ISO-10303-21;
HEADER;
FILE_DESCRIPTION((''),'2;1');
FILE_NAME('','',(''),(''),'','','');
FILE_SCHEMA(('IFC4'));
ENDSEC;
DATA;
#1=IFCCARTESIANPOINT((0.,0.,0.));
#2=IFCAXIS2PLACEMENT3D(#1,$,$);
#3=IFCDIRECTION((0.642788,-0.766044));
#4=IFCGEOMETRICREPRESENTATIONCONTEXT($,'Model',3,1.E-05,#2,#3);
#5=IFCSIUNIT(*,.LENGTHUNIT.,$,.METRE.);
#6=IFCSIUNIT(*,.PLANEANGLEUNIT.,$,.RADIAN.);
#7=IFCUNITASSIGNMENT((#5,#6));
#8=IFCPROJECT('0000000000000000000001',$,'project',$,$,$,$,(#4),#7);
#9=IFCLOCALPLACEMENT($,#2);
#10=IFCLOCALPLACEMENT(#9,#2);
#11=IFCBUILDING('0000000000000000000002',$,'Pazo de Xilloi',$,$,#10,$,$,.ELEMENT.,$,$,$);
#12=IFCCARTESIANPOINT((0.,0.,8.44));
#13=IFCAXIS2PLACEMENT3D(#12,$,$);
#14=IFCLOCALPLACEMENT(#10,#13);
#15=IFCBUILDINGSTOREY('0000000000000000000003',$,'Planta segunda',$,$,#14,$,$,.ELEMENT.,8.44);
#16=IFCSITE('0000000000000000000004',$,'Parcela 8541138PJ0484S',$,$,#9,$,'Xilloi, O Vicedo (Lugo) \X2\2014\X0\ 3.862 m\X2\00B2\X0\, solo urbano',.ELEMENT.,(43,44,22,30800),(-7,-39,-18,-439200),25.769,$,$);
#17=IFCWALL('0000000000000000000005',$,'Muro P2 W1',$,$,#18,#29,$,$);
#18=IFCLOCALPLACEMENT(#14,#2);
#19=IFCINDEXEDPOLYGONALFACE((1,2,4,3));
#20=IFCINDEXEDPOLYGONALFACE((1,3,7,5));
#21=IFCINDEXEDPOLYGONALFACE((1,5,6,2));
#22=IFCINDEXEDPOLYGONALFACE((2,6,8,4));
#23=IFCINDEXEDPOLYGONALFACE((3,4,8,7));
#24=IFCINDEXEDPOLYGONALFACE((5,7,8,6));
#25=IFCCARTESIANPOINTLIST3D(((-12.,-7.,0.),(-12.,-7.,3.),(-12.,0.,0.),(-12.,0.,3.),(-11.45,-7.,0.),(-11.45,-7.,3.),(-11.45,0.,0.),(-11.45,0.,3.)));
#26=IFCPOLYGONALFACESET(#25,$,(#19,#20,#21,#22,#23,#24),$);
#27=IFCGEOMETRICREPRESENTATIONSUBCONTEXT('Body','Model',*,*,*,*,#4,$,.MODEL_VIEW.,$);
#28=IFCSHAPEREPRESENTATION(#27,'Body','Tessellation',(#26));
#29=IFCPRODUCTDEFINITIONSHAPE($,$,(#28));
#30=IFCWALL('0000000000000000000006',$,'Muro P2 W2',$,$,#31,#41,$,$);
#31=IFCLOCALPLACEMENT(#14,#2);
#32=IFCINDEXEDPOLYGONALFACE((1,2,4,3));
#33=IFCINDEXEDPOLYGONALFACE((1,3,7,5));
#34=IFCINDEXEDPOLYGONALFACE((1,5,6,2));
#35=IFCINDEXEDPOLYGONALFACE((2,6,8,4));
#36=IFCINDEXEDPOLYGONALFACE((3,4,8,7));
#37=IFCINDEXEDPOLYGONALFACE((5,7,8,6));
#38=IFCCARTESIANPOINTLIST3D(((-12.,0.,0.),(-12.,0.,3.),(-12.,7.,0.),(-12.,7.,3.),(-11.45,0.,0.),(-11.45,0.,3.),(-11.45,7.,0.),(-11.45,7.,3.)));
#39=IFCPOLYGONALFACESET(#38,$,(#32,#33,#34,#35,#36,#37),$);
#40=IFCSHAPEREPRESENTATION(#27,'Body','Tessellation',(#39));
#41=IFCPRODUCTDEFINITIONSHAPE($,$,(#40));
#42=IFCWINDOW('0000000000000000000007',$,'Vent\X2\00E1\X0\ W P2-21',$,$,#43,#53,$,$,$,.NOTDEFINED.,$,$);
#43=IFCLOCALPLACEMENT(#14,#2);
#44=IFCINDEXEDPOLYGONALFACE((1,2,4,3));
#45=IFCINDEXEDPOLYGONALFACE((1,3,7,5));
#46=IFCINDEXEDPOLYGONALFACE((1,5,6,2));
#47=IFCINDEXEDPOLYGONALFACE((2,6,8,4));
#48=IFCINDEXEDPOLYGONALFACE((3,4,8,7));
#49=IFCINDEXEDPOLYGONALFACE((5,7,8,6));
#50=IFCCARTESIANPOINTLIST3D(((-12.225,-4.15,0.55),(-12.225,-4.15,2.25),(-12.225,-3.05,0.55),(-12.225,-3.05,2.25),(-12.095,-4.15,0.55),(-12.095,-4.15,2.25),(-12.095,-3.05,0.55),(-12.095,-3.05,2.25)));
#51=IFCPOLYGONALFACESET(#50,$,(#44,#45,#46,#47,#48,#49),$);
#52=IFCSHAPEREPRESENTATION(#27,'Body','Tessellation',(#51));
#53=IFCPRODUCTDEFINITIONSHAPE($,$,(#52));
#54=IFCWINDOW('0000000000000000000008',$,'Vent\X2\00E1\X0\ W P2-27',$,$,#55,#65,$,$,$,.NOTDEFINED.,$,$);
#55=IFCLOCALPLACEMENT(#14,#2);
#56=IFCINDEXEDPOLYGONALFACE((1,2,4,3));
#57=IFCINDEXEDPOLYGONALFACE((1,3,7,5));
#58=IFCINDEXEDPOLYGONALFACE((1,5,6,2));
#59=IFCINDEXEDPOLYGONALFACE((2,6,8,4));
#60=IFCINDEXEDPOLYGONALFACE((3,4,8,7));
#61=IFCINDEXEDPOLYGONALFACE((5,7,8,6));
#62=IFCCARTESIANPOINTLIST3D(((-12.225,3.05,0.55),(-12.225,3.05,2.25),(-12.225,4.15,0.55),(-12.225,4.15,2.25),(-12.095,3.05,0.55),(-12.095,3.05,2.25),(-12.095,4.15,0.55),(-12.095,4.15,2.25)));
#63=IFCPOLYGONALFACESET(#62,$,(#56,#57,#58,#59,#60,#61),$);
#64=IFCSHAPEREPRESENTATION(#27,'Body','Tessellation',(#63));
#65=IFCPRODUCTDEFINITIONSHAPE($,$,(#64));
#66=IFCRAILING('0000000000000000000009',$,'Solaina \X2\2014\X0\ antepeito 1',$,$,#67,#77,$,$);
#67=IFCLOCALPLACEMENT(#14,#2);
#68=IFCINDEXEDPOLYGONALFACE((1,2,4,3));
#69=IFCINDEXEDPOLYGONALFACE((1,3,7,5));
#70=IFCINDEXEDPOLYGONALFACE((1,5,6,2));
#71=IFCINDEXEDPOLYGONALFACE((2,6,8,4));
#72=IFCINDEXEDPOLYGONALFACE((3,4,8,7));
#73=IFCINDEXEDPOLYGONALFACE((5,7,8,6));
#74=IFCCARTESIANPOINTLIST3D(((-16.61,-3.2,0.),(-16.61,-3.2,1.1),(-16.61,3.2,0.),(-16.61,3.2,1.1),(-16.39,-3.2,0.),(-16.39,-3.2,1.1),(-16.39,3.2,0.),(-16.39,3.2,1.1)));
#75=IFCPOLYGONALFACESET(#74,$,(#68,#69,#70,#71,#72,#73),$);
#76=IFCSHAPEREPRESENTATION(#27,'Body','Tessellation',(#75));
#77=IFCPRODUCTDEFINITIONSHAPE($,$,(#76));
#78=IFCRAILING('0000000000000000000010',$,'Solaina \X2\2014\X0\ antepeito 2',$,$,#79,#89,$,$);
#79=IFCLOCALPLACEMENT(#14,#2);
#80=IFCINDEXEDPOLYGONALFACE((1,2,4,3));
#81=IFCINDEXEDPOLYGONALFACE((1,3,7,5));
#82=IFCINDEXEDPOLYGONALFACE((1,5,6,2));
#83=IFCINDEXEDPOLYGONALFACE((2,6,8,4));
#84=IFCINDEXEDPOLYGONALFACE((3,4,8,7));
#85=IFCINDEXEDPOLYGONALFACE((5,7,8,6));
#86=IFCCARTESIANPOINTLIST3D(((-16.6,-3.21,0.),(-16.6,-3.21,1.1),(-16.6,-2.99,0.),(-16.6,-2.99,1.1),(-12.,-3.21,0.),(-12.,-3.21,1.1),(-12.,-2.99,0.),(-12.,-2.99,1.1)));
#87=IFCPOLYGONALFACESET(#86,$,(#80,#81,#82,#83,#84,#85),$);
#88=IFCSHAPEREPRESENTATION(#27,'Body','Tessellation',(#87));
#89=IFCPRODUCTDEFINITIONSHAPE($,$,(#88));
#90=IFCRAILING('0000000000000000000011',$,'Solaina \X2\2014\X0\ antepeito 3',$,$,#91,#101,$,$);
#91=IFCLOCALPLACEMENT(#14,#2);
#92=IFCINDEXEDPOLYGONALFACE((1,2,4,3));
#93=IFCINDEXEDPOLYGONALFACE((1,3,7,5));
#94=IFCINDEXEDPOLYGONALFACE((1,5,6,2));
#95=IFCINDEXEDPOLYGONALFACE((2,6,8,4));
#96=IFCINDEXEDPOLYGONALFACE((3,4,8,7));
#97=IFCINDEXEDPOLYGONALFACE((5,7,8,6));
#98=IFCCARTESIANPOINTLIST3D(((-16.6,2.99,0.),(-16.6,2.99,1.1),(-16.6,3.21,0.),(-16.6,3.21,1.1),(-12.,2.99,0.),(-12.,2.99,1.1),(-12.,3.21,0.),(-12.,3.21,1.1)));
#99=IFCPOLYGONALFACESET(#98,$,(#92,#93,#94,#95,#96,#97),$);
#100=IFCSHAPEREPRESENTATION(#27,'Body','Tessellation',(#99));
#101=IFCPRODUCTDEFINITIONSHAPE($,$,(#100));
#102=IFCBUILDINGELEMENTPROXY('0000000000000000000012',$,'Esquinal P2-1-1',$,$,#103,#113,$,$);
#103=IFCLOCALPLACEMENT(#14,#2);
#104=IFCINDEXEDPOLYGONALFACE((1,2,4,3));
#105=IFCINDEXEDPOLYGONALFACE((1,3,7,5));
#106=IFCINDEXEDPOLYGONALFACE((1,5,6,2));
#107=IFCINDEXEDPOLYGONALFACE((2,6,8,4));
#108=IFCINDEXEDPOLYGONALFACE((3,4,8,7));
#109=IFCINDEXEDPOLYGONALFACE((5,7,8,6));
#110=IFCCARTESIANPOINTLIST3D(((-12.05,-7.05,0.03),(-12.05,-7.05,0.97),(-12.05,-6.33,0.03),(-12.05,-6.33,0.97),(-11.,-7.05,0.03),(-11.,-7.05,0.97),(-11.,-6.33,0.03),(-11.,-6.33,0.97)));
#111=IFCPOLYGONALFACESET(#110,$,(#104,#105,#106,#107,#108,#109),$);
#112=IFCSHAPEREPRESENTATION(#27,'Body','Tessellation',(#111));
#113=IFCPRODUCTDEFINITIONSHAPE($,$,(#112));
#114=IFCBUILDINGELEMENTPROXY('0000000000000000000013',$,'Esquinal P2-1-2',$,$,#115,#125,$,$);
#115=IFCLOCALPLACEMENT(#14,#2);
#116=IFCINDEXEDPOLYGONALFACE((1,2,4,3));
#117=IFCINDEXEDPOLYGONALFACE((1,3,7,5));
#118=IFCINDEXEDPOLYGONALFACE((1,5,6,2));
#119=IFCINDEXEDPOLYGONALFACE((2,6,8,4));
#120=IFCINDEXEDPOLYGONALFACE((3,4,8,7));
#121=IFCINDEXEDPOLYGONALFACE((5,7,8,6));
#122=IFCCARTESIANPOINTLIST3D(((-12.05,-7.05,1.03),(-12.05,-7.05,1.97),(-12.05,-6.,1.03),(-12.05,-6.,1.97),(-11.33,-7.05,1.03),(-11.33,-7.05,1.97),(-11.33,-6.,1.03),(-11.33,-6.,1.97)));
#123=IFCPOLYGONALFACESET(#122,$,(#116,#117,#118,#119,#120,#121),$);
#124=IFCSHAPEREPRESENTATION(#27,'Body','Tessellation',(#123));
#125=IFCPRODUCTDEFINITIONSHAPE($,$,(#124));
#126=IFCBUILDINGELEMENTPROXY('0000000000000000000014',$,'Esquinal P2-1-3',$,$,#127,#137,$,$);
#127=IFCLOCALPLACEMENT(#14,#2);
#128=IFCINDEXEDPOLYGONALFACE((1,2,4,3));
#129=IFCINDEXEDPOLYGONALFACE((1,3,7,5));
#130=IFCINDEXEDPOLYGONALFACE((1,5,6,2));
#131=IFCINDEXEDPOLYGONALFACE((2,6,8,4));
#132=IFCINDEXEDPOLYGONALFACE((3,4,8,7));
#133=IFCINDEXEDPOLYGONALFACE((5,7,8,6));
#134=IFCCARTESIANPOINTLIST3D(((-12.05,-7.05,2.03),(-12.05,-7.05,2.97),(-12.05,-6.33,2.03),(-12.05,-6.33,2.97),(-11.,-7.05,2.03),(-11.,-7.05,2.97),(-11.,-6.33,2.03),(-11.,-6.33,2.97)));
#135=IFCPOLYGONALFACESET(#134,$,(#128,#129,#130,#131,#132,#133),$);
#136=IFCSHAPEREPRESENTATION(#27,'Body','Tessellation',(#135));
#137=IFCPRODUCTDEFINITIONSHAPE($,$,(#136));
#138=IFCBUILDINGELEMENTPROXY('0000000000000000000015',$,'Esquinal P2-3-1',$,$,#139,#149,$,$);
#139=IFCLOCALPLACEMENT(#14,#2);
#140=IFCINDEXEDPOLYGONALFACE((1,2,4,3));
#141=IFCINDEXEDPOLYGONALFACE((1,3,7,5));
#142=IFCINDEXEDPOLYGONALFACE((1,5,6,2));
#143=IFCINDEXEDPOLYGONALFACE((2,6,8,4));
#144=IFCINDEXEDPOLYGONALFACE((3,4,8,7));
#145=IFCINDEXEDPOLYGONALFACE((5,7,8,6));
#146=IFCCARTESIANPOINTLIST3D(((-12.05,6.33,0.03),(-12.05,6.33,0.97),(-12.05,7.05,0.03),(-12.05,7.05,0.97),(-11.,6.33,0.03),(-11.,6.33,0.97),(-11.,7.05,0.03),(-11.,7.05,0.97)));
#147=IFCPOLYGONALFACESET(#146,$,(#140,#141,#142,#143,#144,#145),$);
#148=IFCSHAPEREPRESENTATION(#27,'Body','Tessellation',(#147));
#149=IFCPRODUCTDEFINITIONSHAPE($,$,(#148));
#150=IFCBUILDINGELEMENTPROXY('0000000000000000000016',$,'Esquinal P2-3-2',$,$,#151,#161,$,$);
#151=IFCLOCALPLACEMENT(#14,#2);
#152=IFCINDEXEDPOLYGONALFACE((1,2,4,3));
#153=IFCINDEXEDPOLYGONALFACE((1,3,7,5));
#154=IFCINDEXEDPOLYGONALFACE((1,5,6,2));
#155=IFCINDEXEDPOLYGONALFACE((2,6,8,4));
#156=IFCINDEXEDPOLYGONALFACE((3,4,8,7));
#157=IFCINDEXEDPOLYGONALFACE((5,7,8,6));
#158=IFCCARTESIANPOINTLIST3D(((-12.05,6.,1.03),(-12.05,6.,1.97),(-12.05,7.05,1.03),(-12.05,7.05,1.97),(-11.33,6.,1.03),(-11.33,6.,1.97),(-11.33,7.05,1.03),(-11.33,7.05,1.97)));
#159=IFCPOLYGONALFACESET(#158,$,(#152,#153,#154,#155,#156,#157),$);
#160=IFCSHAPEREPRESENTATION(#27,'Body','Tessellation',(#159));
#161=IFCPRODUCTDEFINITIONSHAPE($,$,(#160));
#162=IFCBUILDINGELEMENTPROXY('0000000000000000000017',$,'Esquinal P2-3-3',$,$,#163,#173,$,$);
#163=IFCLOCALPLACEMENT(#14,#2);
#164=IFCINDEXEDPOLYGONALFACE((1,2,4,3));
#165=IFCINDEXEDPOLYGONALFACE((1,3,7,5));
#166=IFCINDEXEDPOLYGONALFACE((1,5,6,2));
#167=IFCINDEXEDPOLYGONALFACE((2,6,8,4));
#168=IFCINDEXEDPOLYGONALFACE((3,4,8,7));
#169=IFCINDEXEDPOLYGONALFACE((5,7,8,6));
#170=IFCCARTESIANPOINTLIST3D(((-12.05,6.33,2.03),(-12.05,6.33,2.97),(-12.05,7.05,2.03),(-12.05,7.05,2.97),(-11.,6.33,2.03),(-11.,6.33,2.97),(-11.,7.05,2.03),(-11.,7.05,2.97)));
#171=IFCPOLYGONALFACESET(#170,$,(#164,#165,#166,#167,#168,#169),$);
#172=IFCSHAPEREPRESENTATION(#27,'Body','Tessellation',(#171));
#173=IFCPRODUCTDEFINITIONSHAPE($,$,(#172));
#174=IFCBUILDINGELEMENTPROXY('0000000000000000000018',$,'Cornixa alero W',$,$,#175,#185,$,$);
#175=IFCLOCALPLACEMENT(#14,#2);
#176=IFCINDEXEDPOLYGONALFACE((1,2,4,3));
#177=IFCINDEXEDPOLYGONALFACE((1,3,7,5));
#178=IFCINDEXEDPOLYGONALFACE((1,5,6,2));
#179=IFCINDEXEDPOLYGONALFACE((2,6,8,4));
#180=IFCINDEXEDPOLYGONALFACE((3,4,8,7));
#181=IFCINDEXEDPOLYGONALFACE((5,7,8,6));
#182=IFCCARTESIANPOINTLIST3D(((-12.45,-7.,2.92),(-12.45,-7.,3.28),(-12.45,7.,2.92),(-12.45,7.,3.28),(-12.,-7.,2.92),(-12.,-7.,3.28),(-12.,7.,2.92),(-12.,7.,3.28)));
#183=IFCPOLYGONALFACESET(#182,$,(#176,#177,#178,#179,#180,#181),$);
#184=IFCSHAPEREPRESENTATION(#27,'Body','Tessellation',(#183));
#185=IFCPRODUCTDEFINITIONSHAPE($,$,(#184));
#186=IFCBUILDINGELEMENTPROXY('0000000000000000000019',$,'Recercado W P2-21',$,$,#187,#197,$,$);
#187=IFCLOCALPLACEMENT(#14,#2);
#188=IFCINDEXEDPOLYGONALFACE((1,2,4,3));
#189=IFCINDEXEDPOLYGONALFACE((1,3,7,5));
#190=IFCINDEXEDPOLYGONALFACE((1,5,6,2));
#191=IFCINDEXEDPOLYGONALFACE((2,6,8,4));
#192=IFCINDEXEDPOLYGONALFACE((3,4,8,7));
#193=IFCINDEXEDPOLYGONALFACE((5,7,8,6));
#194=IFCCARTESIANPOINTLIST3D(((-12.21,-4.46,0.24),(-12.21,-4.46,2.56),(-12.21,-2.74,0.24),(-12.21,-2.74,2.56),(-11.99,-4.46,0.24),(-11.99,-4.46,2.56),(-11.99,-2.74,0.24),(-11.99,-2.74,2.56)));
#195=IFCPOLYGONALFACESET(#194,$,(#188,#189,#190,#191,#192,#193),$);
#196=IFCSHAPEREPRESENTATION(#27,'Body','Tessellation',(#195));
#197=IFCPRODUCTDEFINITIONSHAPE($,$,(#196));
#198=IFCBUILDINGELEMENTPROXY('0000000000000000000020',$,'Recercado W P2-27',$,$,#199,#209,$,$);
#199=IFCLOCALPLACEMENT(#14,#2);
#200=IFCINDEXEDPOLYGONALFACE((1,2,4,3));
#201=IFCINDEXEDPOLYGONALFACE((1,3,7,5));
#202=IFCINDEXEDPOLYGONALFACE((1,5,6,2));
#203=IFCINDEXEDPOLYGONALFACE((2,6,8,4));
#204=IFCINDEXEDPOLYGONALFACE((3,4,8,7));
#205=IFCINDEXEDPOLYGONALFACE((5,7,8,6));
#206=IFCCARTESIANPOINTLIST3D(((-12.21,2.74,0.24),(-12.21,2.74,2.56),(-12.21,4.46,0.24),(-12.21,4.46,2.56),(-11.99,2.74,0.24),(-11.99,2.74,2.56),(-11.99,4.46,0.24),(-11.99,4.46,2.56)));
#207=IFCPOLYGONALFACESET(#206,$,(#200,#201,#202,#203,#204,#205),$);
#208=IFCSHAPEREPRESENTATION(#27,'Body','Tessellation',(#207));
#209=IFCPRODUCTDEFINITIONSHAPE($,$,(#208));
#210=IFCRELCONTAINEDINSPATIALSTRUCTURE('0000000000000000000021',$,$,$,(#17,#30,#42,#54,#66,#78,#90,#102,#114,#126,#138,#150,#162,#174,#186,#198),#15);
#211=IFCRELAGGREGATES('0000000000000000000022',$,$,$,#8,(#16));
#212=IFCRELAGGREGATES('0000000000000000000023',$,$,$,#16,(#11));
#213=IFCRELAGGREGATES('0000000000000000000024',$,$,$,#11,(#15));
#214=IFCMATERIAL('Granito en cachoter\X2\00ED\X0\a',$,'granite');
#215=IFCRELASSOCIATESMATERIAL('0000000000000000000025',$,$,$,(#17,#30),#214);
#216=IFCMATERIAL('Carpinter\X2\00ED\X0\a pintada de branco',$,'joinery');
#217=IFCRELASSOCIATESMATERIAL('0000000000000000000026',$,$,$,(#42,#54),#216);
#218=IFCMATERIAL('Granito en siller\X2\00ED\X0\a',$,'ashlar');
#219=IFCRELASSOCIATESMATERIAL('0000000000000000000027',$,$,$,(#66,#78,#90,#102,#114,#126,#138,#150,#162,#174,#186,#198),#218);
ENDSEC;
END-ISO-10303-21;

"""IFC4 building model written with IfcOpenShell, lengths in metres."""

from ifc_helpers import new_model, si_unit, direction, frame, origin, origin_2d, place, context, subcontext, project, spatial, rectangle, extrude, material, element, save


model = new_model("IFC4")

# Units and contexts
model_context = context("Model", 3, precision=1e-05, world=origin(), true_north=direction((0.642788, -0.766044)))
body_context = subcontext(model_context, "Body", "Model", "MODEL_VIEW")
ifc_project = project(units=[si_unit("LENGTHUNIT", "METRE"), si_unit("PLANEANGLEUNIT", "RADIAN")], contexts=[model_context])

# Site, building, storey
site_placement = place(None, origin())
site = spatial("IfcSite", under=ifc_project, at=site_placement, Name="Parcela 8541138PJ0484S", LongName="Xilloi, O Vicedo (Lugo) — 3.862 m², solo urbano", CompositionType="ELEMENT", RefLatitude=(43, 44, 22, 30800), RefLongitude=(-7, -39, -18, -439200), RefElevation=25.769)
building_placement = place(site_placement, origin())
building = spatial("IfcBuilding", under=site, at=building_placement, Name="Pazo de Xilloi", CompositionType="ELEMENT")
storey_placement = place(building_placement, frame((0.0, 0.0, 8.44)))
storey = spatial("IfcBuildingStorey", under=building, at=storey_placement, Name="Planta segunda", CompositionType="ELEMENT", Elevation=8.44)

# Shared definitions
ifc_material_1 = material(Name="Granito en sillería", Category="ashlar")

# Walls
ifc_material_2 = material(Name="Granito en cachotería", Category="granite")
for number, where, name in (
    (1, (-11.725, -3.5, 1.5), "Muro P2 W1"),
    (2, (-11.725, 3.5, 1.5), "Muro P2 W2"),
):
    element("IfcWall", number, at=place(storey_placement, frame(where)), inside=storey, material=ifc_material_2, Name=name, context=body_context, shape_type="SweptSolid", body=[
        extrude(rectangle(XDim=0.55, YDim=7.0, at=origin_2d()), frame((0.0, 0.0, -1.5)), (0.0, 0.0, 1.0), 3.0),
    ])

# Windows
ifc_material_3 = material(Name="Carpintería pintada de branco", Category="joinery")
for number, where, name in (
    (3, (-12.16, -3.6, 1.4), "Ventá W P2-21"),
    (4, (-12.16, 3.6, 1.4), "Ventá W P2-27"),
):
    element("IfcWindow", number, at=place(storey_placement, frame(where)), inside=storey, material=ifc_material_3, Name=name, PredefinedType="NOTDEFINED", context=body_context, shape_type="SweptSolid", body=[
        extrude(rectangle(XDim=0.13, YDim=1.1, at=origin_2d()), frame((0.0, 0.0, -0.85)), (0.0, 0.0, 1.0), 1.7),
    ])

# Railings
railing_placement = place(storey_placement, frame((-16.5, 0.0, 0.55)))
element("IfcRailing", 5, at=railing_placement, inside=storey, material=ifc_material_1, Name="Solaina — antepeito 1", context=body_context, shape_type="SweptSolid", body=[
    extrude(rectangle(XDim=0.22, YDim=6.4, at=origin_2d()), frame((0.0, 0.0, -0.55)), (0.0, 0.0, 1.0), 1.1),
])
for number, where, name in (
    (6, (-14.3, -3.1, 0.55), "Solaina — antepeito 2"),
    (7, (-14.3, 3.1, 0.55), "Solaina — antepeito 3"),
):
    element("IfcRailing", number, at=place(storey_placement, frame(where)), inside=storey, material=ifc_material_1, Name=name, context=body_context, shape_type="SweptSolid", body=[
        extrude(rectangle(XDim=4.6, YDim=0.22, at=origin_2d()), frame((0.0, 0.0, -0.55)), (0.0, 0.0, 1.0), 1.1),
    ])

# Building element proxies
proxy_1_placement = place(storey_placement, frame((-11.525, -6.69, 0.5)))
element("IfcBuildingElementProxy", 8, at=proxy_1_placement, inside=storey, material=ifc_material_1, Name="Esquinal P2-1-1", context=body_context, shape_type="SweptSolid", body=[
    extrude(rectangle(XDim=1.05, YDim=0.72, at=origin_2d()), frame((0.0, 0.0, -0.47)), (0.0, 0.0, 1.0), 0.94),
])
proxy_2_placement = place(storey_placement, frame((-11.69, -6.525, 1.5)))
element("IfcBuildingElementProxy", 9, at=proxy_2_placement, inside=storey, material=ifc_material_1, Name="Esquinal P2-1-2", context=body_context, shape_type="SweptSolid", body=[
    extrude(rectangle(XDim=0.72, YDim=1.05, at=origin_2d()), frame((0.0, 0.0, -0.47)), (0.0, 0.0, 1.0), 0.94),
])
for number, where, name in (
    (10, (-11.525, -6.69, 2.5), "Esquinal P2-1-3"),
    (11, (-11.525, 6.69, 0.5), "Esquinal P2-3-1"),
):
    element("IfcBuildingElementProxy", number, at=place(storey_placement, frame(where)), inside=storey, material=ifc_material_1, Name=name, context=body_context, shape_type="SweptSolid", body=[
        extrude(rectangle(XDim=1.05, YDim=0.72, at=origin_2d()), frame((0.0, 0.0, -0.47)), (0.0, 0.0, 1.0), 0.94),
    ])
proxy_3_placement = place(storey_placement, frame((-11.69, 6.525, 1.5)))
element("IfcBuildingElementProxy", 12, at=proxy_3_placement, inside=storey, material=ifc_material_1, Name="Esquinal P2-3-2", context=body_context, shape_type="SweptSolid", body=[
    extrude(rectangle(XDim=0.72, YDim=1.05, at=origin_2d()), frame((0.0, 0.0, -0.47)), (0.0, 0.0, 1.0), 0.94),
])
proxy_4_placement = place(storey_placement, frame((-11.525, 6.69, 2.5)))
element("IfcBuildingElementProxy", 13, at=proxy_4_placement, inside=storey, material=ifc_material_1, Name="Esquinal P2-3-3", context=body_context, shape_type="SweptSolid", body=[
    extrude(rectangle(XDim=1.05, YDim=0.72, at=origin_2d()), frame((0.0, 0.0, -0.47)), (0.0, 0.0, 1.0), 0.94),
])
proxy_5_placement = place(storey_placement, frame((-12.225, 0.0, 3.1)))
element("IfcBuildingElementProxy", 14, at=proxy_5_placement, inside=storey, material=ifc_material_1, Name="Cornixa alero W", context=body_context, shape_type="SweptSolid", body=[
    extrude(rectangle(XDim=0.45, YDim=14.0, at=origin_2d()), frame((0.0, 0.0, -0.18)), (0.0, 0.0, 1.0), 0.36),
])
for number, where, name in (
    (15, (-12.1, -3.6, 1.4), "Recercado W P2-21"),
    (16, (-12.1, 3.6, 1.4), "Recercado W P2-27"),
):
    element("IfcBuildingElementProxy", number, at=place(storey_placement, frame(where)), inside=storey, material=ifc_material_1, Name=name, context=body_context, shape_type="SweptSolid", body=[
        extrude(rectangle(XDim=0.22, YDim=1.72, at=origin_2d()), frame((0.0, 0.0, -1.16)), (0.0, 0.0, 1.0), 2.32),
    ])

save(model, "model.ifc")
